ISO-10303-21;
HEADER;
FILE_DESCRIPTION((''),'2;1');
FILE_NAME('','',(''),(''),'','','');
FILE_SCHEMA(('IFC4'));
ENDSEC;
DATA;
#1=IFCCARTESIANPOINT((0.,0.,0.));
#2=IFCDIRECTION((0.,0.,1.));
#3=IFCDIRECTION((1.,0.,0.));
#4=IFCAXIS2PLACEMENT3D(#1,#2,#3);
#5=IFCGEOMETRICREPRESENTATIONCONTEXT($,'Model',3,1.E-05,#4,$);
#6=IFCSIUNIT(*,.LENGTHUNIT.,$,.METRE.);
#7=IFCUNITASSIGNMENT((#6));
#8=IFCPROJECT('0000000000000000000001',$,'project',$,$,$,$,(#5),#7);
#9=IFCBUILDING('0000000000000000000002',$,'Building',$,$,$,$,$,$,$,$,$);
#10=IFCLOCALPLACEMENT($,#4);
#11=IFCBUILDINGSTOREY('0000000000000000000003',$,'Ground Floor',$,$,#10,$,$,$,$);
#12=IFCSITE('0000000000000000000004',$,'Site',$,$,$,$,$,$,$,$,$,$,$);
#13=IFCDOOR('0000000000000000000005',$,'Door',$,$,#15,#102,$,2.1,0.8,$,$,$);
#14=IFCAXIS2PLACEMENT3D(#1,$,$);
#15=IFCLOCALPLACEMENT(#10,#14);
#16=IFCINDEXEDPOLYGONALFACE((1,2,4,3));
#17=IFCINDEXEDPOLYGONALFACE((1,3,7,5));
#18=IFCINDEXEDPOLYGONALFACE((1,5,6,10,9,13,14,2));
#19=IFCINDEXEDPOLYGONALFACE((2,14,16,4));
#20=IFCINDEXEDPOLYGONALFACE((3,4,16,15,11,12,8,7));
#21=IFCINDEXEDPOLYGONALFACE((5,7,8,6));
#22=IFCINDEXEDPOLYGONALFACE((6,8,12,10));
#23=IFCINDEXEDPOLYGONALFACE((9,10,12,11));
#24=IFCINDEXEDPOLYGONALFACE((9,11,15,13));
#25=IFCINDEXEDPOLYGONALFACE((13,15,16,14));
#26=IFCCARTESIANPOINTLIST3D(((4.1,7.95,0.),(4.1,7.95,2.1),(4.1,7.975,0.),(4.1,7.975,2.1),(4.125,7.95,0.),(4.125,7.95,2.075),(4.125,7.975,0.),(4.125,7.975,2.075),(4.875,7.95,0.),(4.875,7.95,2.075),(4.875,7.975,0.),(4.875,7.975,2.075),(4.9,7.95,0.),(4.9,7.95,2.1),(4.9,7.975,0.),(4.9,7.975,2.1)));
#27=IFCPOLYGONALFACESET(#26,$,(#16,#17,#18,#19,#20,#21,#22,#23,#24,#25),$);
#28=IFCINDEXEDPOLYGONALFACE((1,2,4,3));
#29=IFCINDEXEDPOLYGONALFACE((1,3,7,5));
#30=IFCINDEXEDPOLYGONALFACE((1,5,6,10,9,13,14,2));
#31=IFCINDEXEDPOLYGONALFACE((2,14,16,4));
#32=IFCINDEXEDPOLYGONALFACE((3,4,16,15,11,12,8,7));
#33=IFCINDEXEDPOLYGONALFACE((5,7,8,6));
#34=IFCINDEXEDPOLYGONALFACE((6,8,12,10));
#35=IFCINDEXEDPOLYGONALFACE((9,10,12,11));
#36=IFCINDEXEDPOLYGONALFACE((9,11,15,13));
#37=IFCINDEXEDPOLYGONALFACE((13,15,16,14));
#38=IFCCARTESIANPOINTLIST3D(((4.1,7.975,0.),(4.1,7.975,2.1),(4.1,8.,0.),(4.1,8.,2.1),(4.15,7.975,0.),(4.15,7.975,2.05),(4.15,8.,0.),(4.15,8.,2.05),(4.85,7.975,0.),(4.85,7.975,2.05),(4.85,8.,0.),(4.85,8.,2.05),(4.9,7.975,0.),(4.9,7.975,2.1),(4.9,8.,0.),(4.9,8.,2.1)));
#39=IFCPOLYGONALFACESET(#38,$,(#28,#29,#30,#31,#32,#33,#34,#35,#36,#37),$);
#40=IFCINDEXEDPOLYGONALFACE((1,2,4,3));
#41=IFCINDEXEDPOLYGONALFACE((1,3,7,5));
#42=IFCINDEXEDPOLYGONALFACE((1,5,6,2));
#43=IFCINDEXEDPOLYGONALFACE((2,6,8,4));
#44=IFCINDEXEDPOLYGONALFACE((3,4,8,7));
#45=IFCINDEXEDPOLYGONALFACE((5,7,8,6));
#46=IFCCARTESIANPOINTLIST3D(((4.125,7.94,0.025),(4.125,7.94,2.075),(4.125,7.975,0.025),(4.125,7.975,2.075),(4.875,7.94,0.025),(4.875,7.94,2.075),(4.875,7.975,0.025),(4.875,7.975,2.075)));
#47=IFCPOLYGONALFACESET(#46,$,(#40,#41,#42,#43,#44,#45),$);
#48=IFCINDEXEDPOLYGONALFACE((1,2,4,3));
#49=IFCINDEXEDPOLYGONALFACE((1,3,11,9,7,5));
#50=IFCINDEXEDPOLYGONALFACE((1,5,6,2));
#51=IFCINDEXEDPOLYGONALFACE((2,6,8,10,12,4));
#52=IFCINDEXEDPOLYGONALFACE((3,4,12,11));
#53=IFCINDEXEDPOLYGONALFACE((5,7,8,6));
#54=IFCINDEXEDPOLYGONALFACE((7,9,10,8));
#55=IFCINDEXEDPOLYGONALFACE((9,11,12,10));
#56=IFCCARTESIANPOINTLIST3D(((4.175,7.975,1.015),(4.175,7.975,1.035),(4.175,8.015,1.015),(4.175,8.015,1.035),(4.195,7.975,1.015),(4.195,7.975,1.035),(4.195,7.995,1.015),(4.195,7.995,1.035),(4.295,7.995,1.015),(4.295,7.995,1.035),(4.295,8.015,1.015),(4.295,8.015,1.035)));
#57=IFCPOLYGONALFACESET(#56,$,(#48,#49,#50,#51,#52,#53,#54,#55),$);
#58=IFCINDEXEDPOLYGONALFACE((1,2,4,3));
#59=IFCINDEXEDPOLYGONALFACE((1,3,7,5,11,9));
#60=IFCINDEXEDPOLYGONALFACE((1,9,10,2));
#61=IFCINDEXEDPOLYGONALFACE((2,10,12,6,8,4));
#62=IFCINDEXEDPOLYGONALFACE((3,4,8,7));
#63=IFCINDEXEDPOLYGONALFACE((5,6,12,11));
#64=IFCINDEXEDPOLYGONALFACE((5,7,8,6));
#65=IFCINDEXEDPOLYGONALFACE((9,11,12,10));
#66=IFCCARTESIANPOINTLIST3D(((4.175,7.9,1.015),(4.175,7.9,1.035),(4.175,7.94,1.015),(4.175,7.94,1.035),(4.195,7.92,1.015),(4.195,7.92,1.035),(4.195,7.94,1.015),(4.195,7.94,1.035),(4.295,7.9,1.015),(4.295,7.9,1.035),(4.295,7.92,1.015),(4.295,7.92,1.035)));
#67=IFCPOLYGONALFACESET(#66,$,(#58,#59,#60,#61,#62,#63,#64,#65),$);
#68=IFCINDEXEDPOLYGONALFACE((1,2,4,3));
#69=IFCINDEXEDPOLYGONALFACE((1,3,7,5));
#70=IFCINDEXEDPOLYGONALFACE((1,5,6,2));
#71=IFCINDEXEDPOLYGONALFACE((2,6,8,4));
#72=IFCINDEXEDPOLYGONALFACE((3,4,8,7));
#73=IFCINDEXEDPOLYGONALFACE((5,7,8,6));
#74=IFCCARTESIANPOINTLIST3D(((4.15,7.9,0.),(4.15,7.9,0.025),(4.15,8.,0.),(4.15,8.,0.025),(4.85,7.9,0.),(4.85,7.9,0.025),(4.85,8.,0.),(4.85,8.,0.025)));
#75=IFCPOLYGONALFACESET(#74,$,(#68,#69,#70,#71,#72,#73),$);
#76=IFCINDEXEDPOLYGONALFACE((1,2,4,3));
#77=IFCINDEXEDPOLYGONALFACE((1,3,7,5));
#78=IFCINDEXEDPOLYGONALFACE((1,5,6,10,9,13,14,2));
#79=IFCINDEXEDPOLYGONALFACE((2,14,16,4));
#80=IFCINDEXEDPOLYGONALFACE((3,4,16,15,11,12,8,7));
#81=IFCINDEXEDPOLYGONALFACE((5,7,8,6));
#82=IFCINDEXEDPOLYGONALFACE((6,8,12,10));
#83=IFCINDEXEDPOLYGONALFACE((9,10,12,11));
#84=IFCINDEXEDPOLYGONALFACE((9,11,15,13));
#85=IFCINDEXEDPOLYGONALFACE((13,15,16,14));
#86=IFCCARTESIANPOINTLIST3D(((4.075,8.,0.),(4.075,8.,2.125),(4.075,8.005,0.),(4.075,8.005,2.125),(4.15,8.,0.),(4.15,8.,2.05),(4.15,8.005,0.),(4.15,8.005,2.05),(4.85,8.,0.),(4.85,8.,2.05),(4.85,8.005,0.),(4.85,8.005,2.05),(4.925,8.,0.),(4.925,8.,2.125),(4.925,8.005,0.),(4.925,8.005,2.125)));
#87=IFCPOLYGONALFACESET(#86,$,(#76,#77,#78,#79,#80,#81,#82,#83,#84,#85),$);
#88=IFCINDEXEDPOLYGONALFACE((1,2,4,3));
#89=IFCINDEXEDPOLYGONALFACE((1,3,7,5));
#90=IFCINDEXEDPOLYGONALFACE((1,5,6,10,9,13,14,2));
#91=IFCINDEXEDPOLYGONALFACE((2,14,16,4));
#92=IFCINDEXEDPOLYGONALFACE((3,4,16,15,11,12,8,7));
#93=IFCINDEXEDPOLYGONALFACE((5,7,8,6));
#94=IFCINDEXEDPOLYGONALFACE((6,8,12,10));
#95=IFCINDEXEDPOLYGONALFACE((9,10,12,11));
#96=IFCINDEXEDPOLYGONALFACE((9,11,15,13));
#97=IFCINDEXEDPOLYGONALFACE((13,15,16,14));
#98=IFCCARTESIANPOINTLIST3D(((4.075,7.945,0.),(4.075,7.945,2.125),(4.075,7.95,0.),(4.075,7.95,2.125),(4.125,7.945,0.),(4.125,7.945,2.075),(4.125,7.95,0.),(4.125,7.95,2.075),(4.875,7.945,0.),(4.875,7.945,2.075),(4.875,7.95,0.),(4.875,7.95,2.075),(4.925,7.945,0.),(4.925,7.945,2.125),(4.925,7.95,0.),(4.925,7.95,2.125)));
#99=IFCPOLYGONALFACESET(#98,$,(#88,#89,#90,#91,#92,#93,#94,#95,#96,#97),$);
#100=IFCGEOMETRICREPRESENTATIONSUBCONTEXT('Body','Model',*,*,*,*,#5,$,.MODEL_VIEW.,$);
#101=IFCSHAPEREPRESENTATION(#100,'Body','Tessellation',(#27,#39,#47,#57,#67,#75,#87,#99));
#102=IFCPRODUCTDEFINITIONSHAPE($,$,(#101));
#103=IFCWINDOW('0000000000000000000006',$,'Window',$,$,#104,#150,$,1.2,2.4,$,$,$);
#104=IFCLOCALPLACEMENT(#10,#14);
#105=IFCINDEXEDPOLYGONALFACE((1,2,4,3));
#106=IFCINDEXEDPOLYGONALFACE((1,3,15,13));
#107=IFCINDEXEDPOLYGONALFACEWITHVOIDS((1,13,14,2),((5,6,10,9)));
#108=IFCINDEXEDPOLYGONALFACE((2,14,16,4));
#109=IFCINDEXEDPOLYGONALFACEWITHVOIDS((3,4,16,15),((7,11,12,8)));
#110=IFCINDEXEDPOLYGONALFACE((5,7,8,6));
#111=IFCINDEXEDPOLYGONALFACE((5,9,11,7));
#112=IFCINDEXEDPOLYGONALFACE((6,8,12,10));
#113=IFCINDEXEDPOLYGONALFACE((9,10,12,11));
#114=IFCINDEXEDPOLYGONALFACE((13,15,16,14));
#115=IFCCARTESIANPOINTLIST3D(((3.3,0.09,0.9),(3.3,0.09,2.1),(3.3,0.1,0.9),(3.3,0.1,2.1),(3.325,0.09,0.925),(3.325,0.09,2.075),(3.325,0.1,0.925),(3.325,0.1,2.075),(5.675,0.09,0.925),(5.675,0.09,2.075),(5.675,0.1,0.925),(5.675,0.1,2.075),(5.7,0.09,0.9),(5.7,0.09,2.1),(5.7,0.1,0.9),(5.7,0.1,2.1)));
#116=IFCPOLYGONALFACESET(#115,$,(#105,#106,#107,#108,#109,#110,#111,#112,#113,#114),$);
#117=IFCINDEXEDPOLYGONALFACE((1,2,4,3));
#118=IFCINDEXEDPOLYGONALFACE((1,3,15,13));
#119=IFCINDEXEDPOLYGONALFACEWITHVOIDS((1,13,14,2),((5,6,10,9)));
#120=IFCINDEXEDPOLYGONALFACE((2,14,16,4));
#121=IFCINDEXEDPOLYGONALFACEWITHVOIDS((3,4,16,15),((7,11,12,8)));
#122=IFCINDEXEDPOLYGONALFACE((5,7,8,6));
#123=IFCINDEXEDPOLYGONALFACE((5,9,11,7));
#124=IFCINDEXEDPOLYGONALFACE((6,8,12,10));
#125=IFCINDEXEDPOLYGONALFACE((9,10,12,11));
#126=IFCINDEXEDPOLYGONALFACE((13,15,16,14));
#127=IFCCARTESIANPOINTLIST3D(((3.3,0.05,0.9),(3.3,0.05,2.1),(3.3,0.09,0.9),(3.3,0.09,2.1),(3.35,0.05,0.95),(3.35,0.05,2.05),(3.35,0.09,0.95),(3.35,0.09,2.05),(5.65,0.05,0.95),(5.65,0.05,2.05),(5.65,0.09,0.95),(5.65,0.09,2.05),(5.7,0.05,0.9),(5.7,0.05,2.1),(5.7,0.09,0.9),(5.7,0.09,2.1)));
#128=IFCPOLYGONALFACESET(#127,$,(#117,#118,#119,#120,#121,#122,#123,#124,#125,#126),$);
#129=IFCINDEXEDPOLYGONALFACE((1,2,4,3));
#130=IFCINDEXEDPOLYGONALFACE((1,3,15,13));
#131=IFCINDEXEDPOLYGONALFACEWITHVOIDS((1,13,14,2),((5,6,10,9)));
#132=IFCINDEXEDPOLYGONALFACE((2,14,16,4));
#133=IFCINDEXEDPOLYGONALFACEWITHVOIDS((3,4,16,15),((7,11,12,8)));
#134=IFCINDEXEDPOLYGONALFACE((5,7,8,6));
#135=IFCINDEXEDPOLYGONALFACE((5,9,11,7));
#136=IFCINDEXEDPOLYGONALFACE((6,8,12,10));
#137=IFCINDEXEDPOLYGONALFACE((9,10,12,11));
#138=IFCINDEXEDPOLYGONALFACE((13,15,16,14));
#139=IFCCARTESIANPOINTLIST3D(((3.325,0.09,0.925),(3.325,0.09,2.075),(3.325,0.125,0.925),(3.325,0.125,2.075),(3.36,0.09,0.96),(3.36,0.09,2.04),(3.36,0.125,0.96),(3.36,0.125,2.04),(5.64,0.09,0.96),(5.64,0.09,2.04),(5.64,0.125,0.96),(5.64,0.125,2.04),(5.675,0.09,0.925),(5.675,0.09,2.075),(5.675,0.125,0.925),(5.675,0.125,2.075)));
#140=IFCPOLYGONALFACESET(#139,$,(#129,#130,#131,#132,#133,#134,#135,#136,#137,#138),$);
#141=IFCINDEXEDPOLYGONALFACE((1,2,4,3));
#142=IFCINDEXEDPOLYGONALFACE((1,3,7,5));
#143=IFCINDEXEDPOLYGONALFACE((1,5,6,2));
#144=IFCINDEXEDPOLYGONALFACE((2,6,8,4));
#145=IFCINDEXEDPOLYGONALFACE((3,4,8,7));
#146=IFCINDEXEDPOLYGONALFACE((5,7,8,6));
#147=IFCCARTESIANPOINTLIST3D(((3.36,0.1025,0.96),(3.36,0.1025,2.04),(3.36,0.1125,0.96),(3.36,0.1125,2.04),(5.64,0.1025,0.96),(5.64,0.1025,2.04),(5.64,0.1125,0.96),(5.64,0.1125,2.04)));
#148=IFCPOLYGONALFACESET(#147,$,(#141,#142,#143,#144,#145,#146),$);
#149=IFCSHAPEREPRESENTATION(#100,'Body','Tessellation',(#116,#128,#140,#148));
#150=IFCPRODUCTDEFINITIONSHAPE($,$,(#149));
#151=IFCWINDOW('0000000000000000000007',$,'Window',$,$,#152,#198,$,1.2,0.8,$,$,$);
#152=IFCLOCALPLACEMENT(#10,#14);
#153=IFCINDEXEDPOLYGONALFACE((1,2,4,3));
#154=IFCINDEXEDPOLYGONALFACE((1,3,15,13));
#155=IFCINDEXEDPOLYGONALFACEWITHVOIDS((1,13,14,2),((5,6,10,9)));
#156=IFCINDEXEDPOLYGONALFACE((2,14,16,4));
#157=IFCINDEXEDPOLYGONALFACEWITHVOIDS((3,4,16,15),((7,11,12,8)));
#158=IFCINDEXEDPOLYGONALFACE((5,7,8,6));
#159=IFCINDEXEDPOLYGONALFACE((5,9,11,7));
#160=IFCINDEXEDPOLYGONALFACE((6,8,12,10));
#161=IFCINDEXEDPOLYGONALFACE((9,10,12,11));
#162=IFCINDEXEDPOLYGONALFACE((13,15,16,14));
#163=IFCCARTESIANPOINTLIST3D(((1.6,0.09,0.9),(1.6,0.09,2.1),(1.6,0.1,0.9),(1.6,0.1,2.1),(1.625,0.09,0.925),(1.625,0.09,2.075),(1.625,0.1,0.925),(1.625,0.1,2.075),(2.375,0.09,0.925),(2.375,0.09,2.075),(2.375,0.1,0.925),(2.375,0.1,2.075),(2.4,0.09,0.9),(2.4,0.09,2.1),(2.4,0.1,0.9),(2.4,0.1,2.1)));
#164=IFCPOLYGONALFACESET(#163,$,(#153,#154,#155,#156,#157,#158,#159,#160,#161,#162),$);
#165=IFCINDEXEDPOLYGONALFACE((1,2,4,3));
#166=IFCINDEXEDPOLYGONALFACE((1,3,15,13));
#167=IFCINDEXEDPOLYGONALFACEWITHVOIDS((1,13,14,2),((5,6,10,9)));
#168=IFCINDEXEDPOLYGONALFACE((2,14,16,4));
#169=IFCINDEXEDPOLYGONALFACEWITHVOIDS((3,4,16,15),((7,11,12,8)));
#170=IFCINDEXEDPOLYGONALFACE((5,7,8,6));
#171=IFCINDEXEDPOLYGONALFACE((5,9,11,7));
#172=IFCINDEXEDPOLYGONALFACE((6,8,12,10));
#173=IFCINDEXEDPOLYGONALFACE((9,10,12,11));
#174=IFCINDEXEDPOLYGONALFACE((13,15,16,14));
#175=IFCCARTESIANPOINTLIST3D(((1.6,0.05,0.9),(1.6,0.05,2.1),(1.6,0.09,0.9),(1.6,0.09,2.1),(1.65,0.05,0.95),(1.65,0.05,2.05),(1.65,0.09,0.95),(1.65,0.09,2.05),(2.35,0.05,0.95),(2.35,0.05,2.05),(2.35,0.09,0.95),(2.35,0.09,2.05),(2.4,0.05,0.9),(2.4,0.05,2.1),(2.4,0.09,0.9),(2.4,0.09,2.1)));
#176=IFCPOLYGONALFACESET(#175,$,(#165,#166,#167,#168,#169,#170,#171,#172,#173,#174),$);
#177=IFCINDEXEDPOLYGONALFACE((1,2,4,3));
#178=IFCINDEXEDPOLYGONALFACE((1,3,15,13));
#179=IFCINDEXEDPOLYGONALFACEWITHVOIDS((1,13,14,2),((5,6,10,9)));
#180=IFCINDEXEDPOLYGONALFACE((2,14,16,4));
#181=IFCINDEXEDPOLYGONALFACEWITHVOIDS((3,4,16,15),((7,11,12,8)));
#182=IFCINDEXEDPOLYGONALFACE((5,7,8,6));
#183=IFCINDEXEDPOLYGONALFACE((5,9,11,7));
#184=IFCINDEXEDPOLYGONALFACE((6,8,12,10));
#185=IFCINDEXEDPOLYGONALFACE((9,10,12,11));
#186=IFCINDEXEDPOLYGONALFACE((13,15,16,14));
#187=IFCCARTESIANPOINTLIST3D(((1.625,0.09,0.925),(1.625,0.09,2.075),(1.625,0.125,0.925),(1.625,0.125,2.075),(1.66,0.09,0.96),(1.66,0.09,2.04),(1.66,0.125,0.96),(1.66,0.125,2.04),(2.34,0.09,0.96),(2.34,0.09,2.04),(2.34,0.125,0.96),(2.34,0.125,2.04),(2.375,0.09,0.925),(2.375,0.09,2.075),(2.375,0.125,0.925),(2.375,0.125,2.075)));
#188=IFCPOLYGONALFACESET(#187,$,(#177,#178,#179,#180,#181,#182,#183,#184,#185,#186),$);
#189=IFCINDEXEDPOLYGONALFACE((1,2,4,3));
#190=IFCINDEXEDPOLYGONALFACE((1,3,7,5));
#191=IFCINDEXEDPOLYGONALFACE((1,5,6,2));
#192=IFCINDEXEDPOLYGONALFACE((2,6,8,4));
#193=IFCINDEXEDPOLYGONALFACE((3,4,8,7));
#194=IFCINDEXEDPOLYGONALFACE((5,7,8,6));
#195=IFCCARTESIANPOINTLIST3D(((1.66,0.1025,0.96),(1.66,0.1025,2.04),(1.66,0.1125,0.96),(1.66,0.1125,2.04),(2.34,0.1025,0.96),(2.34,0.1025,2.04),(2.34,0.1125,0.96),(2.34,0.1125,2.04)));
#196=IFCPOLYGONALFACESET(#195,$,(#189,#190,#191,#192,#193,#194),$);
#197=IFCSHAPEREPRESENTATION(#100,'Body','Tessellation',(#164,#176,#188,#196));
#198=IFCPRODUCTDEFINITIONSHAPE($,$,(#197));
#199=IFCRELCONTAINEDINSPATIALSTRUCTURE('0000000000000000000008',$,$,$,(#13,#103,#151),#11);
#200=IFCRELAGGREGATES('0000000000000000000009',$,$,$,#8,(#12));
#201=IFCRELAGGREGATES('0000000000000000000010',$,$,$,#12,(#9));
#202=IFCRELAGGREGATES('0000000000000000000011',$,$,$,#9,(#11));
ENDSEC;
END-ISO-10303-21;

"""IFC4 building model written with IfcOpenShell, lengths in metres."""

from ifc_helpers import new_model, si_unit, frame, origin_with_axes, place, context, subcontext, project, spatial, line, indexed_curve, outline, extrude, element, save


model = new_model("IFC4")

# Units and contexts
model_context = context("Model", 3, precision=1e-05, world=origin_with_axes())
body_context = subcontext(model_context, "Body", "Model", "MODEL_VIEW")
ifc_project = project(units=[si_unit("LENGTHUNIT", "METRE")], contexts=[model_context])

# Site, building, storey
site = spatial("IfcSite", under=ifc_project, Name="Site")
building = spatial("IfcBuilding", under=site, Name="Building")
storey_placement = place(None, origin_with_axes())
storey = spatial("IfcBuildingStorey", under=building, at=storey_placement, Name="Ground Floor")

# Door
door_1_placement = place(storey_placement, frame((4.9, 8.0, 0.0), z_axis=(0.0, 0.0, 1.0), x_axis=(-1.0, 0.0, 0.0)))
element("IfcDoor", 1, at=door_1_placement, inside=storey, Name="Door", OverallHeight=2.1, OverallWidth=0.8, context=body_context, shape_type="SweptSolid", body=[
    extrude(outline(indexed_curve([(0.0, 0.0), (0.0, 2.1), (0.8, 2.1), (0.8, 0.0), (0.775, 0.0), (0.775, 2.075), (0.025, 2.075), (0.025, 0.0)], segments=[line(1, 2, 3, 4, 5, 6, 7, 8, 1)])), frame((0.0, 0.025, 0.0), z_axis=(0.0, -1.0, 0.0), x_axis=(1.0, 0.0, 0.0)), (0.0, 0.0, -1.0), 0.025),
    extrude(outline(indexed_curve([(0.0, 0.0), (0.0, 2.1), (0.8, 2.1), (0.8, 0.0), (0.75, 0.0), (0.75, 2.05), (0.05, 2.05), (0.05, 0.0)], segments=[line(1, 2, 3, 4, 5, 6, 7, 8, 1)])), frame((0.0, 0.0, 0.0), z_axis=(0.0, -1.0, 0.0), x_axis=(1.0, 0.0, 0.0)), (0.0, 0.0, -1.0), 0.025),
    extrude(outline(indexed_curve([(0.0, 0.0), (0.75, 0.0), (0.75, 0.035), (0.0, 0.035)], segments=[line(1, 2, 3, 4, 1)])), frame((0.025, 0.025, 0.025), z_axis=(0.0, 0.0, 1.0), x_axis=(1.0, 0.0, 0.0)), (0.0, 0.0, 1.0), 2.05),
    extrude(outline(indexed_curve([(0.0, 0.0), (0.0, -0.04), (-0.12, -0.04), (-0.12, -0.02), (-0.02, -0.02), (-0.02, 0.0)], segments=[line(1, 2, 3, 4, 5, 6, 1)])), frame((0.725, 0.025, 1.015), z_axis=(0.0, 0.0, 1.0), x_axis=(1.0, 0.0, 0.0)), (0.0, 0.0, 1.0), 0.02),
    extrude(outline(indexed_curve([(0.0, 0.0), (0.0, 0.04), (-0.12, 0.04), (-0.12, 0.02), (-0.02, 0.02), (-0.02, 0.0)], segments=[line(1, 2, 3, 4, 5, 6, 1)])), frame((0.725, 0.06, 1.015), z_axis=(0.0, 0.0, 1.0), x_axis=(1.0, 0.0, 0.0)), (0.0, 0.0, 1.0), 0.02),
    extrude(outline(indexed_curve([(0.0, 0.0), (0.7, 0.0), (0.7, 0.1), (0.0, 0.1)], segments=[line(1, 2, 3, 4, 1)])), frame((0.05, 0.0, 0.0), z_axis=(0.0, 0.0, 1.0), x_axis=(1.0, 0.0, 0.0)), (0.0, 0.0, 1.0), 0.025),
    extrude(outline(indexed_curve([(0.0, 0.0), (0.0, 2.125), (0.85, 2.125), (0.85, 0.0), (0.775, 0.0), (0.775, 2.05), (0.075, 2.05), (0.075, 0.0)], segments=[line(1, 2, 3, 4, 5, 6, 7, 8, 1)])), frame((-0.025, -0.005, 0.0), z_axis=(0.0, -1.0, 0.0), x_axis=(1.0, 0.0, 0.0)), (0.0, 0.0, -1.0), 0.005),
    extrude(outline(indexed_curve([(0.0, 0.0), (0.0, 2.125), (0.85, 2.125), (0.85, 0.0), (0.8, 0.0), (0.8, 2.075), (0.05, 2.075), (0.05, 0.0)], segments=[line(1, 2, 3, 4, 5, 6, 7, 8, 1)])), frame((-0.025, 0.05, 0.0), z_axis=(0.0, -1.0, 0.0), x_axis=(1.0, 0.0, 0.0)), (0.0, 0.0, -1.0), 0.005),
])

# Windows
window_1_placement = place(storey_placement, frame((3.3, 0.0, 0.9), z_axis=(0.0, 0.0, 1.0), x_axis=(1.0, 0.0, 0.0)))
element("IfcWindow", 2, at=window_1_placement, inside=storey, Name="Window", OverallHeight=1.2, OverallWidth=2.4, context=body_context, shape_type="SweptSolid", body=[
    extrude(outline(indexed_curve([(0.0, 0.0), (2.4, 0.0), (2.4, 1.2), (0.0, 1.2)], segments=[line(1, 2, 3, 4, 1)]), holes=[indexed_curve([(0.025, 0.025), (2.375, 0.025), (2.375, 1.175), (0.025, 1.175)], segments=[line(1, 2, 3, 4, 1)])]), frame((0.0, 0.09, 0.0), z_axis=(0.0, -1.0, 0.0), x_axis=(1.0, 0.0, 0.0)), (0.0, 0.0, -1.0), 0.01),
    extrude(outline(indexed_curve([(0.0, 0.0), (2.4, 0.0), (2.4, 1.2), (0.0, 1.2)], segments=[line(1, 2, 3, 4, 1)]), holes=[indexed_curve([(0.05, 0.05), (2.35, 0.05), (2.35, 1.15), (0.05, 1.15)], segments=[line(1, 2, 3, 4, 1)])]), frame((0.0, 0.05, 0.0), z_axis=(0.0, -1.0, 0.0), x_axis=(1.0, 0.0, 0.0)), (0.0, 0.0, -1.0), 0.04),
    extrude(outline(indexed_curve([(0.0, 0.0), (2.35, 0.0), (2.35, 1.15), (0.0, 1.15)], segments=[line(1, 2, 3, 4, 1)]), holes=[indexed_curve([(0.035, 0.035), (2.315, 0.035), (2.315, 1.115), (0.035, 1.115)], segments=[line(1, 2, 3, 4, 1)])]), frame((0.025, 0.09, 0.025), z_axis=(0.0, -1.0, 0.0), x_axis=(1.0, 0.0, 0.0)), (0.0, 0.0, -1.0), 0.035),
    extrude(outline(indexed_curve([(0.035, 0.035), (2.315, 0.035), (2.315, 1.115), (0.035, 1.115)], segments=[line(1, 2, 3, 4, 1)])), frame((0.025, 0.1025, 0.025), z_axis=(0.0, -1.0, 0.0), x_axis=(1.0, 0.0, 0.0)), (0.0, 0.0, -1.0), 0.01),
])
window_2_placement = place(storey_placement, frame((1.6, 0.0, 0.9), z_axis=(0.0, 0.0, 1.0), x_axis=(1.0, 0.0, 0.0)))
element("IfcWindow", 3, at=window_2_placement, inside=storey, Name="Window", OverallHeight=1.2, OverallWidth=0.8, context=body_context, shape_type="SweptSolid", body=[
    extrude(outline(indexed_curve([(0.0, 0.0), (0.8, 0.0), (0.8, 1.2), (0.0, 1.2)], segments=[line(1, 2, 3, 4, 1)]), holes=[indexed_curve([(0.025, 0.025), (0.775, 0.025), (0.775, 1.175), (0.025, 1.175)], segments=[line(1, 2, 3, 4, 1)])]), frame((0.0, 0.09, 0.0), z_axis=(0.0, -1.0, 0.0), x_axis=(1.0, 0.0, 0.0)), (0.0, 0.0, -1.0), 0.01),
    extrude(outline(indexed_curve([(0.0, 0.0), (0.8, 0.0), (0.8, 1.2), (0.0, 1.2)], segments=[line(1, 2, 3, 4, 1)]), holes=[indexed_curve([(0.05, 0.05), (0.75, 0.05), (0.75, 1.15), (0.05, 1.15)], segments=[line(1, 2, 3, 4, 1)])]), frame((0.0, 0.05, 0.0), z_axis=(0.0, -1.0, 0.0), x_axis=(1.0, 0.0, 0.0)), (0.0, 0.0, -1.0), 0.04),
    extrude(outline(indexed_curve([(0.0, 0.0), (0.75, 0.0), (0.75, 1.15), (0.0, 1.15)], segments=[line(1, 2, 3, 4, 1)]), holes=[indexed_curve([(0.035, 0.035), (0.715, 0.035), (0.715, 1.115), (0.035, 1.115)], segments=[line(1, 2, 3, 4, 1)])]), frame((0.025, 0.09, 0.025), z_axis=(0.0, -1.0, 0.0), x_axis=(1.0, 0.0, 0.0)), (0.0, 0.0, -1.0), 0.035),
    extrude(outline(indexed_curve([(0.035, 0.035), (0.715, 0.035), (0.715, 1.115), (0.035, 1.115)], segments=[line(1, 2, 3, 4, 1)])), frame((0.025, 0.1025, 0.025), z_axis=(0.0, -1.0, 0.0), x_axis=(1.0, 0.0, 0.0)), (0.0, 0.0, -1.0), 0.01),
])

save(model, "model.ifc")
